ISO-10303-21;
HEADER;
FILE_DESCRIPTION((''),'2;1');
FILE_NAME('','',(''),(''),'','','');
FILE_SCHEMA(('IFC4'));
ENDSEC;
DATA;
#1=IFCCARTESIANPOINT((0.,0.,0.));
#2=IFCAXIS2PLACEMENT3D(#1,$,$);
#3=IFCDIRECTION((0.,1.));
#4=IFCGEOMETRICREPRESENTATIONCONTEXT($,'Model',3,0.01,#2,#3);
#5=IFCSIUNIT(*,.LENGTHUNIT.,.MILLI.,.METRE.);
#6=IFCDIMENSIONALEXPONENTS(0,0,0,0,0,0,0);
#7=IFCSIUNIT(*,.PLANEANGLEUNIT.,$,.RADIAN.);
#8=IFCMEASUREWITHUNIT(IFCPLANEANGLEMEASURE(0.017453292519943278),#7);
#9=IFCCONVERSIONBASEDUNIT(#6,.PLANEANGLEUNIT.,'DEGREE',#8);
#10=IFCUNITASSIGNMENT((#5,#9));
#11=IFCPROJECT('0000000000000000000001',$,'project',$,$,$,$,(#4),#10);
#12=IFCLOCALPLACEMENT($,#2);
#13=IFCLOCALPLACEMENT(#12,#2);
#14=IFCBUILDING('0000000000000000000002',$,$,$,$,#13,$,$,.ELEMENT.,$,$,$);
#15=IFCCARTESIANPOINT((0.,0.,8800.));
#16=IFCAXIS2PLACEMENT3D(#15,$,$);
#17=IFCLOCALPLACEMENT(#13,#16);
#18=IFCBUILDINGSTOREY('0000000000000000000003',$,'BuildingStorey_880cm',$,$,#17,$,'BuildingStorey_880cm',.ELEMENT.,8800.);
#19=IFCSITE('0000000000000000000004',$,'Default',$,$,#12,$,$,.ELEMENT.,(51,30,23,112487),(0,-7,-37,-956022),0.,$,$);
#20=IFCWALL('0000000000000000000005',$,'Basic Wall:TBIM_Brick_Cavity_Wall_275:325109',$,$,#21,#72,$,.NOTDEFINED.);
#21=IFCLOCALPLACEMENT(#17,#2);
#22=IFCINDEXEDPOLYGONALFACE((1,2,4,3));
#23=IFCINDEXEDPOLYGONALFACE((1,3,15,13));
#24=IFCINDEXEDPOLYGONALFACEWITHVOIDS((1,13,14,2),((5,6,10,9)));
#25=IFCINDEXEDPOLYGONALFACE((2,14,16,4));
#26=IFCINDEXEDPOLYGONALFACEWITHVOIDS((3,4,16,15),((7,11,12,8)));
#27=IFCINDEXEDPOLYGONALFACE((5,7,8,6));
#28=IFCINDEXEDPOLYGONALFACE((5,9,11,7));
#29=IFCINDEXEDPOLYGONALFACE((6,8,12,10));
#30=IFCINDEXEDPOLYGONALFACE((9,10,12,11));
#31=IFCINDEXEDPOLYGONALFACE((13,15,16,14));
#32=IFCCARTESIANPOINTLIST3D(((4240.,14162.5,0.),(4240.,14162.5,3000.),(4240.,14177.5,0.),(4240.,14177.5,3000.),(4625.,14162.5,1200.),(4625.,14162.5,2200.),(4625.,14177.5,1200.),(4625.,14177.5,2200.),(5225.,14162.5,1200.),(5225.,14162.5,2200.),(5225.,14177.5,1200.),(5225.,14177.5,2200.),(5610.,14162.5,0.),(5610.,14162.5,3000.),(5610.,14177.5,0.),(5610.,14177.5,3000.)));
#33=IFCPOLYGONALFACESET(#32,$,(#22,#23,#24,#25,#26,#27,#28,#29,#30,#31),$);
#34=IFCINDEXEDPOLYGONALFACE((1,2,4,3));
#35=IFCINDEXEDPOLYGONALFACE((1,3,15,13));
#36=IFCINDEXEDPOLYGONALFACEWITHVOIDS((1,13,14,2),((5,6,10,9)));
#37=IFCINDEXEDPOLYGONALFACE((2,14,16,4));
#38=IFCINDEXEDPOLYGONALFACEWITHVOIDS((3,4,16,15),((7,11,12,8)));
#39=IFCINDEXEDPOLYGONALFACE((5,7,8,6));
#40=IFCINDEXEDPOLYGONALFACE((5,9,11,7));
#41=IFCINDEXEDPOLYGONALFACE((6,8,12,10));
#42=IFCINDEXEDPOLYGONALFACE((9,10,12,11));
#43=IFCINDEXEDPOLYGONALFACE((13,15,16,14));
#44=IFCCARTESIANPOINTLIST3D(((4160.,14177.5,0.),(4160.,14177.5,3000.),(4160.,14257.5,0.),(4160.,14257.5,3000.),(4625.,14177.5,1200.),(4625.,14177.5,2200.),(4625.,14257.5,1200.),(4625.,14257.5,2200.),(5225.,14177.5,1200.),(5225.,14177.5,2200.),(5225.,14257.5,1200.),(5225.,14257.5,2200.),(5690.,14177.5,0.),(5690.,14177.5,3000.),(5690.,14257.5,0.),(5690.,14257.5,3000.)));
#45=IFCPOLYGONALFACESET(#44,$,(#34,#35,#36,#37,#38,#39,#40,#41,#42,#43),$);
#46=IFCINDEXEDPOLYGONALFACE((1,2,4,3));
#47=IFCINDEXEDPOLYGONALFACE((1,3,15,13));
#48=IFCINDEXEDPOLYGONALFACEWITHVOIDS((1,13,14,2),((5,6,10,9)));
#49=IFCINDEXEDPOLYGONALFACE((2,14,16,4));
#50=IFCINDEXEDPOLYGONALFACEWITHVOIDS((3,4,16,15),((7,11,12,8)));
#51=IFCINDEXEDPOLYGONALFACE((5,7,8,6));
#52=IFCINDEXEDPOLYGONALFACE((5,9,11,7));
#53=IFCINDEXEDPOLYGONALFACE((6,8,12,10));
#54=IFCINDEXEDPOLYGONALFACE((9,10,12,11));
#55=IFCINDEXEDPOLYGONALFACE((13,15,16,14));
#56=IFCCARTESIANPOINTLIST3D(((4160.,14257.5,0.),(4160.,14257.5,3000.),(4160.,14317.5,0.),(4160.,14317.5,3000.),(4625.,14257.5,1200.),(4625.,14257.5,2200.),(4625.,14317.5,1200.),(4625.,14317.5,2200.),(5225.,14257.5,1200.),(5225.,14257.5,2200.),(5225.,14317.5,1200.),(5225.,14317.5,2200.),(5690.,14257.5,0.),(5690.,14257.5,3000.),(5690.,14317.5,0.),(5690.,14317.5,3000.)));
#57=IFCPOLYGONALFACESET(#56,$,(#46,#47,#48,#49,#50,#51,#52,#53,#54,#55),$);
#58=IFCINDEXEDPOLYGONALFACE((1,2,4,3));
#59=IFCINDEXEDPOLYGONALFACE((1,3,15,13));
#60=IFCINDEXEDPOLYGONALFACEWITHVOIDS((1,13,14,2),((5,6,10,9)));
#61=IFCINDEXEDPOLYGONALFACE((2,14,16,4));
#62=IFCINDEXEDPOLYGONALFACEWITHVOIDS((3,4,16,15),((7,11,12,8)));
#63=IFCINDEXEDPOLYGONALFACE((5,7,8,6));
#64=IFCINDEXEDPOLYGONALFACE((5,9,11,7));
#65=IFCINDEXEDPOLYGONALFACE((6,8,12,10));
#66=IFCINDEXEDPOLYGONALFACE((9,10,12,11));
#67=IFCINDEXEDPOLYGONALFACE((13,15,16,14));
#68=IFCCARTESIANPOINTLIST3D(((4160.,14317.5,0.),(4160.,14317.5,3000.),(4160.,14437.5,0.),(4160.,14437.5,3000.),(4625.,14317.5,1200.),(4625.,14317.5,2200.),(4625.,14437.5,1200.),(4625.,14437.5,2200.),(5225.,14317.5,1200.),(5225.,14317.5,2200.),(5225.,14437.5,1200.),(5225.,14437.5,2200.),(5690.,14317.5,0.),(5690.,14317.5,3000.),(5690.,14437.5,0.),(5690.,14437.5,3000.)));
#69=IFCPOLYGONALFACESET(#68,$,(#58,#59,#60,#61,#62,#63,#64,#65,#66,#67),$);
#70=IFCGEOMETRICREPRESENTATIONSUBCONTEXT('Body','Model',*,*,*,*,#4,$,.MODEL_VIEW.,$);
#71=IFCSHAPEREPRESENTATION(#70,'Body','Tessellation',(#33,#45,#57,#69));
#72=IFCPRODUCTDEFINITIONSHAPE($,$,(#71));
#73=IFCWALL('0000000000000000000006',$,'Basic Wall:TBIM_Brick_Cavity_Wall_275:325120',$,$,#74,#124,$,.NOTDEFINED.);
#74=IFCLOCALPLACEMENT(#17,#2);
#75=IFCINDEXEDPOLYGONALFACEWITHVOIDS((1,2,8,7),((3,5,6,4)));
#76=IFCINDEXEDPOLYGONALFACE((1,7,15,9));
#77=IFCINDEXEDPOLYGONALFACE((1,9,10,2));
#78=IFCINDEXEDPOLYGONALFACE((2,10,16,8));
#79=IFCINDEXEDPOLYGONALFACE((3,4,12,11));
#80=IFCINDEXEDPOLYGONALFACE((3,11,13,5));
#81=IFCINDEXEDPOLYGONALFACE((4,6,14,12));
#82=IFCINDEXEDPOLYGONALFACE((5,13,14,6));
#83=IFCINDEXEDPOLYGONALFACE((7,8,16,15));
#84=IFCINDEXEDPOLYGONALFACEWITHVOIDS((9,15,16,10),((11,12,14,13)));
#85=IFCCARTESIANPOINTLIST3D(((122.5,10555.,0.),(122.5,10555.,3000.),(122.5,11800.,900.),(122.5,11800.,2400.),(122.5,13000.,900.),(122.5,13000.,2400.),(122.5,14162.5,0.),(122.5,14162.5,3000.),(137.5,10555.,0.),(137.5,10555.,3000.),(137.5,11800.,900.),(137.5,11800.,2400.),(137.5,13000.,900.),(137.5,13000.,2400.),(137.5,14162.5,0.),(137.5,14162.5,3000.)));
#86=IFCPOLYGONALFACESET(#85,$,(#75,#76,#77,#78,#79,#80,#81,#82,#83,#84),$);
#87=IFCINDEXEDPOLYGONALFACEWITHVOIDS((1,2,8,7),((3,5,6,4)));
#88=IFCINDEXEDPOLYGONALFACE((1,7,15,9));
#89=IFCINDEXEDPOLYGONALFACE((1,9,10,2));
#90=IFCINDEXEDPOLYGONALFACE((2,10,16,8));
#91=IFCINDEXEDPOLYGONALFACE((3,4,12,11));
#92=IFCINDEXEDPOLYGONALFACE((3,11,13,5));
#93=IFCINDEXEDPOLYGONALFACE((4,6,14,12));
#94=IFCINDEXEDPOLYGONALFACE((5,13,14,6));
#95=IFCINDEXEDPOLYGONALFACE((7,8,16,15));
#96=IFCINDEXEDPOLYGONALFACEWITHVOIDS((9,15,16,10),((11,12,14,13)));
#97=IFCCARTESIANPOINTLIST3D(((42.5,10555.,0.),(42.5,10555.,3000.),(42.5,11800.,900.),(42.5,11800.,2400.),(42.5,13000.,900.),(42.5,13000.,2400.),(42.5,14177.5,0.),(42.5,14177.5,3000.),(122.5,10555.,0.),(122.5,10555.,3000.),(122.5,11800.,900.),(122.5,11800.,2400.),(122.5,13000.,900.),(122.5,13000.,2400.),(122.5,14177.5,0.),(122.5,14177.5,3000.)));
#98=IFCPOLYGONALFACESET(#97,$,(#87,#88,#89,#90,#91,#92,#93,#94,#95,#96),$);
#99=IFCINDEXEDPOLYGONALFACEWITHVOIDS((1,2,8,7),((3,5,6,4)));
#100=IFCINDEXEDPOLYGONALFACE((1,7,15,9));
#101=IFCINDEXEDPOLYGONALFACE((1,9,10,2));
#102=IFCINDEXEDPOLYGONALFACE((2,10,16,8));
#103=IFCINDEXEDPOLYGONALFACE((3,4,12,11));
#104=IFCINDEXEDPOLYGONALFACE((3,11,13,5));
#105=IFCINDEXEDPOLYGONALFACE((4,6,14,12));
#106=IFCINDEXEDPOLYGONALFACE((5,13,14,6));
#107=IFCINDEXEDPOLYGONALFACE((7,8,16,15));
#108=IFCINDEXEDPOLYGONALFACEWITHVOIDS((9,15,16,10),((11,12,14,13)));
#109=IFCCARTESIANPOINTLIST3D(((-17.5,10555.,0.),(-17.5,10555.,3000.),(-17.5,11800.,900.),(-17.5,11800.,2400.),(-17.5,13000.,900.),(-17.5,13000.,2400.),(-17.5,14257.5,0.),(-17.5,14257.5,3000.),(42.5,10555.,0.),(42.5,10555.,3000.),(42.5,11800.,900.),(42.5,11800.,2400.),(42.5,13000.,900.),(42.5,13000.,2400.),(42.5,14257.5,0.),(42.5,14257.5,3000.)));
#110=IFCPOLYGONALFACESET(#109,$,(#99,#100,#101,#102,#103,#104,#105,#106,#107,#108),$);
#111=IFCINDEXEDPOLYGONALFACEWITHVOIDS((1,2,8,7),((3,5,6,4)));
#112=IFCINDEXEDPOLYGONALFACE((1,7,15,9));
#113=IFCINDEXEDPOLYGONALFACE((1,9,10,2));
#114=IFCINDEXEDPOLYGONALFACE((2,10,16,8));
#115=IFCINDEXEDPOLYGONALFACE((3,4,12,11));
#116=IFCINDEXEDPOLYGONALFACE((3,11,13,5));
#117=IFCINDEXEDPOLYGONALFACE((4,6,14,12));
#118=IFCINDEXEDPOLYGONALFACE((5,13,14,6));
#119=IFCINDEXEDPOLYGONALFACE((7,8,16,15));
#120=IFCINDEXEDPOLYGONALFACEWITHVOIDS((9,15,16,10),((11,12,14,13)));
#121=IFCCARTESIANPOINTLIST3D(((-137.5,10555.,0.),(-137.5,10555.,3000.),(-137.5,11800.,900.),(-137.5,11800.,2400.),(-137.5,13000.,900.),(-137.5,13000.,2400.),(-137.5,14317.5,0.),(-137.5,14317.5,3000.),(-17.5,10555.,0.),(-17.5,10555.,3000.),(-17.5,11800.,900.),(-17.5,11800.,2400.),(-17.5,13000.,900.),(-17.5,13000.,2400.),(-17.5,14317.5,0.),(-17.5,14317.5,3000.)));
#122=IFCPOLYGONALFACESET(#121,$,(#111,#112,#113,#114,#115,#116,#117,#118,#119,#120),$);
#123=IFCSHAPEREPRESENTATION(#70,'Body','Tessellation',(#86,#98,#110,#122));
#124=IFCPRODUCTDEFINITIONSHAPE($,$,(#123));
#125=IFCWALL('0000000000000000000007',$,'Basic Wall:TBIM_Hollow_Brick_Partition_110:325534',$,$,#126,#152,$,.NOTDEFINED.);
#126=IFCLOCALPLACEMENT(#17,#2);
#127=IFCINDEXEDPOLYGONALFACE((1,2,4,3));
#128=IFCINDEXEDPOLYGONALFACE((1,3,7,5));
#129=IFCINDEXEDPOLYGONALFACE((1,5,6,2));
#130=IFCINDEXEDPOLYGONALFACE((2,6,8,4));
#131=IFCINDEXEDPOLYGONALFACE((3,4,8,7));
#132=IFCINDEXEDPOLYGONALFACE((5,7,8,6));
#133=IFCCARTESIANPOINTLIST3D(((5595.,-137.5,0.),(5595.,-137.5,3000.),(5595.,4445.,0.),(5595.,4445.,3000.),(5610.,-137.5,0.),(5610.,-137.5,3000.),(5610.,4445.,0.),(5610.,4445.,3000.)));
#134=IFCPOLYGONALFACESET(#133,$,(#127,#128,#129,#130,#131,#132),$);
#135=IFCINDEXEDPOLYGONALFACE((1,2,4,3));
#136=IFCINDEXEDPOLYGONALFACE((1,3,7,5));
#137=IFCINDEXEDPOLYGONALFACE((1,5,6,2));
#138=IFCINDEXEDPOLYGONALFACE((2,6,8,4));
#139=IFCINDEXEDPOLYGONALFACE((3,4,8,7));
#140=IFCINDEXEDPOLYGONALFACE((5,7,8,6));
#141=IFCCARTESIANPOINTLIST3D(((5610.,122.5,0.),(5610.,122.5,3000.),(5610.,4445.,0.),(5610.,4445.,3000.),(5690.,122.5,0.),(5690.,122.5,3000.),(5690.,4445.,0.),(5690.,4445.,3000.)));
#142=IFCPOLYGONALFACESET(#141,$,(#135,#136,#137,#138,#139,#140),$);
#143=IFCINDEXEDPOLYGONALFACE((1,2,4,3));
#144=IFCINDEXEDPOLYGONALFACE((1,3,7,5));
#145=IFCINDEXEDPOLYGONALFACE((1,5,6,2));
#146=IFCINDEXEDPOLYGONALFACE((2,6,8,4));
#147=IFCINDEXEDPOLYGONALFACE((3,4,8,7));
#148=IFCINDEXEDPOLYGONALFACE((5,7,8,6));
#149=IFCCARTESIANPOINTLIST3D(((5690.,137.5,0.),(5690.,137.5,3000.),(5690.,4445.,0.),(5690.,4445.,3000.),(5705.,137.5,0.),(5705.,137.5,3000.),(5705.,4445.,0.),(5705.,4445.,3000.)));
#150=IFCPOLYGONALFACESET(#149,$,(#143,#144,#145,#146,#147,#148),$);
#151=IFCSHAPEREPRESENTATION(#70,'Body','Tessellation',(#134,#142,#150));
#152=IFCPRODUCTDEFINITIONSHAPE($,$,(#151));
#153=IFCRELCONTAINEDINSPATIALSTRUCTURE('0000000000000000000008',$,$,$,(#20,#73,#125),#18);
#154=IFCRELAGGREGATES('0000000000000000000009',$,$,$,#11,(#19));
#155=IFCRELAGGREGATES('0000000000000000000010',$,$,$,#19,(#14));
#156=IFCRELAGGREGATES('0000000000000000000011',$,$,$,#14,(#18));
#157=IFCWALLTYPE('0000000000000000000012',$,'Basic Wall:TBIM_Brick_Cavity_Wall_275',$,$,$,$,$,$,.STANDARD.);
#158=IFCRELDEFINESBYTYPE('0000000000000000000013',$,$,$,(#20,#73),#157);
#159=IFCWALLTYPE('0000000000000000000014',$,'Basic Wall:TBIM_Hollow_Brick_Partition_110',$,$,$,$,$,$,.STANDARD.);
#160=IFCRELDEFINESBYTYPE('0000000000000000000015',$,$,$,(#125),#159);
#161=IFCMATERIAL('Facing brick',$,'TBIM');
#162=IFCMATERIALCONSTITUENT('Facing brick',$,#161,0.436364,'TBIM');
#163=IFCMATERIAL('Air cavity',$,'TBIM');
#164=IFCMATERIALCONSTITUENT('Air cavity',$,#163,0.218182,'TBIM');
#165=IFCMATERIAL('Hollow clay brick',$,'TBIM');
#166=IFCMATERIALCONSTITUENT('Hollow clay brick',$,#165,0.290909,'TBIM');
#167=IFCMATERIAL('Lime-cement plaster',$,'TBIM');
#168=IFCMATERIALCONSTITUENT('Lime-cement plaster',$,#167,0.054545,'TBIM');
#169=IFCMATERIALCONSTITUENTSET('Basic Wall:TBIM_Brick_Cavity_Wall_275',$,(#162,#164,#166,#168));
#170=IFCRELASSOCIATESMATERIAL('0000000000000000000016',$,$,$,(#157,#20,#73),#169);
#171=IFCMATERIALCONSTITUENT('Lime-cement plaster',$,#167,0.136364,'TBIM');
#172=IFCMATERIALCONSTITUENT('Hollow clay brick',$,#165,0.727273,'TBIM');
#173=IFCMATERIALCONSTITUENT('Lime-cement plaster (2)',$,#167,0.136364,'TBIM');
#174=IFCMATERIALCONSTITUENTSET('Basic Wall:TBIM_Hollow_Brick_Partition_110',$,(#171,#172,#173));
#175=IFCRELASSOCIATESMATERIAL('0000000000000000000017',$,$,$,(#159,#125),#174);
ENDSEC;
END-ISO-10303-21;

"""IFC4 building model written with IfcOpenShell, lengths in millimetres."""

from ifc_helpers import new_model, entity, si_unit, converted_unit, direction, frame, origin, place, context, subcontext, project, spatial, indexed_curve, outline, extrude, material, constituent, constituent_set, type_object, element, save


model = new_model("IFC4")

# Units and contexts
model_context = context("Model", 3, precision=0.01, world=origin(), true_north=direction((0.0, 1.0)))
body_context = subcontext(model_context, "Body", "Model", "MODEL_VIEW")
ifc_project = project(units=[si_unit("LENGTHUNIT", "METRE", prefix="MILLI"), converted_unit("PLANEANGLEUNIT", "DEGREE", entity("IfcPlaneAngleMeasure", 0.017453292519943278), si_unit("PLANEANGLEUNIT", "RADIAN"), dimensions=[0, 0, 0, 0, 0, 0, 0])], contexts=[model_context])

# Site, building, storey
site_placement = place(None, origin())
site = spatial("IfcSite", under=ifc_project, at=site_placement, Name="Default", CompositionType="ELEMENT", RefLatitude=(51, 30, 23, 112487), RefLongitude=(0, -7, -37, -956022), RefElevation=0.0)
building_placement = place(site_placement, origin())
building = spatial("IfcBuilding", under=site, at=building_placement, CompositionType="ELEMENT")
storey_placement = place(building_placement, frame((0.0, 0.0, 8800.0)))
storey = spatial("IfcBuildingStorey", under=building, at=storey_placement, Name="BuildingStorey_880cm", LongName="BuildingStorey_880cm", CompositionType="ELEMENT", Elevation=8800.0)

# Shared definitions
ifc_material_1 = material(Name="Lime-cement plaster", Category="TBIM")

# Walls, openings
ifc_material_2 = material(Name="Facing brick", Category="TBIM")
ifc_constituent_1 = constituent(ifc_material_2, Name="Facing brick", Category="TBIM", fraction=0.436364)
ifc_material_3 = material(Name="Air cavity", Category="TBIM")
ifc_constituent_2 = constituent(ifc_material_3, Name="Air cavity", Category="TBIM", fraction=0.218182)
ifc_material_4 = material(Name="Hollow clay brick", Category="TBIM")
ifc_constituent_3 = constituent(ifc_material_4, Name="Hollow clay brick", Category="TBIM", fraction=0.290909)
ifc_constituent_4 = constituent(ifc_material_1, Name="Lime-cement plaster", Category="TBIM", fraction=0.054545)
ifc_constituent_set_1 = constituent_set(constituents=[ifc_constituent_1, ifc_constituent_2, ifc_constituent_3, ifc_constituent_4], Name="Basic Wall:TBIM_Brick_Cavity_Wall_275")
wall_type_1 = type_object("IfcWallType", Name="Basic Wall:TBIM_Brick_Cavity_Wall_275", PredefinedType="STANDARD", material=ifc_constituent_set_1)
wall_1_placement = place(storey_placement, frame((5705.0, 14300.0, 0.0), z_axis=(0.0, 0.0, 1.0), x_axis=(-1.0, 0.0, 0.0)))
wall_1 = element("IfcWall", 1, at=wall_1_placement, inside=storey, type_object=wall_type_1, material=ifc_constituent_set_1, Name="Basic Wall:TBIM_Brick_Cavity_Wall_275:325109", PredefinedType="NOTDEFINED", context=body_context, shape_type="SweptSolid", body=[
    extrude(outline(indexed_curve([(-685.0, -1500.0), (-670.0, -1500.0), (670.0, -1500.0), (685.0, -1500.0), (685.0, 1500.0), (670.0, 1500.0), (-670.0, 1500.0), (-685.0, 1500.0), (-685.0, -1500.0)], self_intersect=False), holes=[indexed_curve([(-300.0, 700.0), (300.0, 700.0), (300.0, -300.0), (-300.0, -300.0), (-300.0, 700.0)], self_intersect=False)]), frame((780.0, 137.5, 1500.0), z_axis=(0.0, -1.0, 0.0), x_axis=(1.0, 0.0, 0.0)), (0.0, 0.0, 1.0), 15.0),
    extrude(outline(indexed_curve([(-1500.0, -765.0), (1500.0, -765.0), (1500.0, 765.0), (-1500.0, 765.0), (-1500.0, -765.0)], self_intersect=False), holes=[indexed_curve([(700.0, 300.0), (700.0, -300.0), (-300.0, -300.0), (-300.0, 300.0), (700.0, 300.0)], self_intersect=False)]), frame((780.0, 122.5, 1500.0), z_axis=(0.0, -1.0, 0.0), x_axis=(0.0, 0.0, 1.0)), (0.0, 0.0, 1.0), 80.0),
    extrude(outline(indexed_curve([(-1500.0, -765.0), (1500.0, -765.0), (1500.0, 765.0), (-1500.0, 765.0), (-1500.0, -765.0)], self_intersect=False), holes=[indexed_curve([(700.0, 300.0), (700.0, -300.0), (-300.0, -300.0), (-300.0, 300.0), (700.0, 300.0)], self_intersect=False)]), frame((780.0, 42.5, 1500.0), z_axis=(0.0, -1.0, 0.0), x_axis=(0.0, 0.0, 1.0)), (0.0, 0.0, 1.0), 60.0),
    extrude(outline(indexed_curve([(-1500.0, -765.0), (1500.0, -765.0), (1500.0, 765.0), (-1500.0, 765.0), (-1500.0, -765.0)], self_intersect=False), holes=[indexed_curve([(700.0, 300.0), (700.0, -300.0), (-300.0, -300.0), (-300.0, 300.0), (700.0, 300.0)], self_intersect=False)]), frame((780.0, -17.5, 1500.0), z_axis=(0.0, -1.0, 0.0), x_axis=(0.0, 0.0, 1.0)), (0.0, 0.0, 1.0), 120.0),
])
opening_1_placement = place(wall_1_placement, frame((480.0, -137.5, 1200.0)))
element("IfcOpeningElement", 2, at=opening_1_placement, cuts=wall_1, PredefinedType="OPENING", context=body_context, shape_type="SweptSolid", body=[
    extrude(outline(indexed_curve([(1000.0, 0.0), (1000.0, 600.0), (0.0, 600.0), (0.0, 0.0), (1000.0, 0.0)], self_intersect=False)), frame((0.0, 0.0, 0.0), z_axis=(0.0, 1.0, 0.0), x_axis=(0.0, 0.0, 1.0)), (0.0, 0.0, 1.0), 275.0),
])
wall_2_placement = place(storey_placement, frame((0.0, 10555.0, 0.0), z_axis=(0.0, 0.0, 1.0), x_axis=(0.0, 1.0, 0.0)))
wall_2 = element("IfcWall", 3, at=wall_2_placement, inside=storey, type_object=wall_type_1, material=ifc_constituent_set_1, Name="Basic Wall:TBIM_Brick_Cavity_Wall_275:325120", PredefinedType="NOTDEFINED", context=body_context, shape_type="SweptSolid", body=[
    extrude(outline(indexed_curve([(-1500.0, -1803.7), (1500.0, -1803.8), (1500.0, 1803.7), (-1500.0, 1803.7), (-1500.0, -1803.7)], self_intersect=False), holes=[indexed_curve([(900.0, 558.8), (900.0, -641.2), (-600.0, -641.2), (-600.0, 558.8), (900.0, 558.8)], self_intersect=False)]), frame((1803.7, -122.5, 1500.0), z_axis=(0.0, -1.0, 0.0), x_axis=(0.0, 0.0, 1.0)), (0.0, 0.0, 1.0), 15.0),
    extrude(outline(indexed_curve([(-1500.0, -1811.2), (1500.0, -1811.2), (1500.0, 1811.2), (-1500.0, 1811.2), (-1500.0, -1811.2)], self_intersect=False), holes=[indexed_curve([(900.0, 566.3), (900.0, -633.7), (-600.0, -633.7), (-600.0, 566.3), (900.0, 566.3)], self_intersect=False)]), frame((1811.2, -42.5, 1500.0), z_axis=(0.0, -1.0, 0.0), x_axis=(0.0, 0.0, 1.0)), (0.0, 0.0, 1.0), 80.0),
    extrude(outline(indexed_curve([(-1500.0, -1851.2), (1500.0, -1851.2), (1500.0, 1851.2), (-1500.0, 1851.2), (-1500.0, -1851.2)], self_intersect=False), holes=[indexed_curve([(900.0, 606.3), (900.0, -593.7), (-600.0, -593.7), (-600.0, 606.3), (900.0, 606.3)], self_intersect=False)]), frame((1851.2, 17.5, 1500.0), z_axis=(0.0, -1.0, 0.0), x_axis=(0.0, 0.0, 1.0)), (0.0, 0.0, 1.0), 60.0),
    extrude(outline(indexed_curve([(-1881.2, -1500.0), (1881.2, -1500.0), (1881.2, 1500.0), (-1881.2, 1500.0), (-1881.2, -1500.0)], self_intersect=False), holes=[indexed_curve([(-636.3, 900.0), (563.7, 900.0), (563.7, -600.0), (-636.3, -600.0), (-636.3, 900.0)], self_intersect=False)]), frame((1881.2, 137.5, 1500.0), z_axis=(0.0, -1.0, 0.0), x_axis=(1.0, 0.0, 0.0)), (0.0, 0.0, 1.0), 120.0),
])
opening_2_placement = place(wall_2_placement, frame((1245.0, -137.5, 900.0)))
element("IfcOpeningElement", 4, at=opening_2_placement, cuts=wall_2, PredefinedType="OPENING", context=body_context, shape_type="SweptSolid", body=[
    extrude(outline(indexed_curve([(1500.0, 0.0), (1500.0, 1200.0), (0.0, 1200.0), (0.0, 0.0), (1500.0, 0.0)], self_intersect=False)), frame((0.0, 0.0, 0.0), z_axis=(0.0, 1.0, 0.0), x_axis=(0.0, 0.0, 1.0)), (0.0, 0.0, 1.0), 275.0),
])

# Wall
ifc_constituent_5 = constituent(ifc_material_1, Name="Lime-cement plaster", Category="TBIM", fraction=0.136364)
ifc_constituent_6 = constituent(ifc_material_4, Name="Hollow clay brick", Category="TBIM", fraction=0.727273)
ifc_constituent_7 = constituent(ifc_material_1, Name="Lime-cement plaster (2)", Category="TBIM", fraction=0.136364)
ifc_constituent_set_2 = constituent_set(constituents=[ifc_constituent_5, ifc_constituent_6, ifc_constituent_7], Name="Basic Wall:TBIM_Hollow_Brick_Partition_110")
wall_type_2 = type_object("IfcWallType", Name="Basic Wall:TBIM_Hollow_Brick_Partition_110", PredefinedType="STANDARD", material=ifc_constituent_set_2)
wall_3_placement = place(storey_placement, frame((5650.0, 137.5, 0.0), z_axis=(0.0, 0.0, 1.0), x_axis=(0.0, 1.0, 0.0)))
element("IfcWall", 5, at=wall_3_placement, inside=storey, type_object=wall_type_2, material=ifc_constituent_set_2, Name="Basic Wall:TBIM_Hollow_Brick_Partition_110:325534", PredefinedType="NOTDEFINED", context=body_context, shape_type="SweptSolid", body=[
    extrude(outline(indexed_curve([(-7.5, -2291.2), (7.5, -2291.2), (7.5, 2291.2), (-7.5, 2291.2), (-7.5, -2291.2)], self_intersect=False)), frame((2016.2, 47.5, 0.0), z_axis=(0.0, 0.0, 1.0), x_axis=(0.0, -1.0, 0.0)), (0.0, 0.0, 1.0), 3000.0),
    extrude(outline(indexed_curve([(-2161.2, -40.0), (2161.2, -40.0), (2161.2, 40.0), (-2161.3, 40.0), (-2161.2, -40.0)], self_intersect=False)), frame((2146.2, 0.0, 0.0)), (0.0, 0.0, 1.0), 3000.0),
    extrude(outline(indexed_curve([(-7.5, -2153.8), (7.5, -2153.8), (7.5, 2153.8), (-7.5, 2153.8), (-7.5, -2153.8)], self_intersect=False)), frame((2153.8, -47.5, 0.0), z_axis=(0.0, 0.0, 1.0), x_axis=(0.0, 1.0, 0.0)), (0.0, 0.0, 1.0), 3000.0),
])

save(model, "model.ifc")
